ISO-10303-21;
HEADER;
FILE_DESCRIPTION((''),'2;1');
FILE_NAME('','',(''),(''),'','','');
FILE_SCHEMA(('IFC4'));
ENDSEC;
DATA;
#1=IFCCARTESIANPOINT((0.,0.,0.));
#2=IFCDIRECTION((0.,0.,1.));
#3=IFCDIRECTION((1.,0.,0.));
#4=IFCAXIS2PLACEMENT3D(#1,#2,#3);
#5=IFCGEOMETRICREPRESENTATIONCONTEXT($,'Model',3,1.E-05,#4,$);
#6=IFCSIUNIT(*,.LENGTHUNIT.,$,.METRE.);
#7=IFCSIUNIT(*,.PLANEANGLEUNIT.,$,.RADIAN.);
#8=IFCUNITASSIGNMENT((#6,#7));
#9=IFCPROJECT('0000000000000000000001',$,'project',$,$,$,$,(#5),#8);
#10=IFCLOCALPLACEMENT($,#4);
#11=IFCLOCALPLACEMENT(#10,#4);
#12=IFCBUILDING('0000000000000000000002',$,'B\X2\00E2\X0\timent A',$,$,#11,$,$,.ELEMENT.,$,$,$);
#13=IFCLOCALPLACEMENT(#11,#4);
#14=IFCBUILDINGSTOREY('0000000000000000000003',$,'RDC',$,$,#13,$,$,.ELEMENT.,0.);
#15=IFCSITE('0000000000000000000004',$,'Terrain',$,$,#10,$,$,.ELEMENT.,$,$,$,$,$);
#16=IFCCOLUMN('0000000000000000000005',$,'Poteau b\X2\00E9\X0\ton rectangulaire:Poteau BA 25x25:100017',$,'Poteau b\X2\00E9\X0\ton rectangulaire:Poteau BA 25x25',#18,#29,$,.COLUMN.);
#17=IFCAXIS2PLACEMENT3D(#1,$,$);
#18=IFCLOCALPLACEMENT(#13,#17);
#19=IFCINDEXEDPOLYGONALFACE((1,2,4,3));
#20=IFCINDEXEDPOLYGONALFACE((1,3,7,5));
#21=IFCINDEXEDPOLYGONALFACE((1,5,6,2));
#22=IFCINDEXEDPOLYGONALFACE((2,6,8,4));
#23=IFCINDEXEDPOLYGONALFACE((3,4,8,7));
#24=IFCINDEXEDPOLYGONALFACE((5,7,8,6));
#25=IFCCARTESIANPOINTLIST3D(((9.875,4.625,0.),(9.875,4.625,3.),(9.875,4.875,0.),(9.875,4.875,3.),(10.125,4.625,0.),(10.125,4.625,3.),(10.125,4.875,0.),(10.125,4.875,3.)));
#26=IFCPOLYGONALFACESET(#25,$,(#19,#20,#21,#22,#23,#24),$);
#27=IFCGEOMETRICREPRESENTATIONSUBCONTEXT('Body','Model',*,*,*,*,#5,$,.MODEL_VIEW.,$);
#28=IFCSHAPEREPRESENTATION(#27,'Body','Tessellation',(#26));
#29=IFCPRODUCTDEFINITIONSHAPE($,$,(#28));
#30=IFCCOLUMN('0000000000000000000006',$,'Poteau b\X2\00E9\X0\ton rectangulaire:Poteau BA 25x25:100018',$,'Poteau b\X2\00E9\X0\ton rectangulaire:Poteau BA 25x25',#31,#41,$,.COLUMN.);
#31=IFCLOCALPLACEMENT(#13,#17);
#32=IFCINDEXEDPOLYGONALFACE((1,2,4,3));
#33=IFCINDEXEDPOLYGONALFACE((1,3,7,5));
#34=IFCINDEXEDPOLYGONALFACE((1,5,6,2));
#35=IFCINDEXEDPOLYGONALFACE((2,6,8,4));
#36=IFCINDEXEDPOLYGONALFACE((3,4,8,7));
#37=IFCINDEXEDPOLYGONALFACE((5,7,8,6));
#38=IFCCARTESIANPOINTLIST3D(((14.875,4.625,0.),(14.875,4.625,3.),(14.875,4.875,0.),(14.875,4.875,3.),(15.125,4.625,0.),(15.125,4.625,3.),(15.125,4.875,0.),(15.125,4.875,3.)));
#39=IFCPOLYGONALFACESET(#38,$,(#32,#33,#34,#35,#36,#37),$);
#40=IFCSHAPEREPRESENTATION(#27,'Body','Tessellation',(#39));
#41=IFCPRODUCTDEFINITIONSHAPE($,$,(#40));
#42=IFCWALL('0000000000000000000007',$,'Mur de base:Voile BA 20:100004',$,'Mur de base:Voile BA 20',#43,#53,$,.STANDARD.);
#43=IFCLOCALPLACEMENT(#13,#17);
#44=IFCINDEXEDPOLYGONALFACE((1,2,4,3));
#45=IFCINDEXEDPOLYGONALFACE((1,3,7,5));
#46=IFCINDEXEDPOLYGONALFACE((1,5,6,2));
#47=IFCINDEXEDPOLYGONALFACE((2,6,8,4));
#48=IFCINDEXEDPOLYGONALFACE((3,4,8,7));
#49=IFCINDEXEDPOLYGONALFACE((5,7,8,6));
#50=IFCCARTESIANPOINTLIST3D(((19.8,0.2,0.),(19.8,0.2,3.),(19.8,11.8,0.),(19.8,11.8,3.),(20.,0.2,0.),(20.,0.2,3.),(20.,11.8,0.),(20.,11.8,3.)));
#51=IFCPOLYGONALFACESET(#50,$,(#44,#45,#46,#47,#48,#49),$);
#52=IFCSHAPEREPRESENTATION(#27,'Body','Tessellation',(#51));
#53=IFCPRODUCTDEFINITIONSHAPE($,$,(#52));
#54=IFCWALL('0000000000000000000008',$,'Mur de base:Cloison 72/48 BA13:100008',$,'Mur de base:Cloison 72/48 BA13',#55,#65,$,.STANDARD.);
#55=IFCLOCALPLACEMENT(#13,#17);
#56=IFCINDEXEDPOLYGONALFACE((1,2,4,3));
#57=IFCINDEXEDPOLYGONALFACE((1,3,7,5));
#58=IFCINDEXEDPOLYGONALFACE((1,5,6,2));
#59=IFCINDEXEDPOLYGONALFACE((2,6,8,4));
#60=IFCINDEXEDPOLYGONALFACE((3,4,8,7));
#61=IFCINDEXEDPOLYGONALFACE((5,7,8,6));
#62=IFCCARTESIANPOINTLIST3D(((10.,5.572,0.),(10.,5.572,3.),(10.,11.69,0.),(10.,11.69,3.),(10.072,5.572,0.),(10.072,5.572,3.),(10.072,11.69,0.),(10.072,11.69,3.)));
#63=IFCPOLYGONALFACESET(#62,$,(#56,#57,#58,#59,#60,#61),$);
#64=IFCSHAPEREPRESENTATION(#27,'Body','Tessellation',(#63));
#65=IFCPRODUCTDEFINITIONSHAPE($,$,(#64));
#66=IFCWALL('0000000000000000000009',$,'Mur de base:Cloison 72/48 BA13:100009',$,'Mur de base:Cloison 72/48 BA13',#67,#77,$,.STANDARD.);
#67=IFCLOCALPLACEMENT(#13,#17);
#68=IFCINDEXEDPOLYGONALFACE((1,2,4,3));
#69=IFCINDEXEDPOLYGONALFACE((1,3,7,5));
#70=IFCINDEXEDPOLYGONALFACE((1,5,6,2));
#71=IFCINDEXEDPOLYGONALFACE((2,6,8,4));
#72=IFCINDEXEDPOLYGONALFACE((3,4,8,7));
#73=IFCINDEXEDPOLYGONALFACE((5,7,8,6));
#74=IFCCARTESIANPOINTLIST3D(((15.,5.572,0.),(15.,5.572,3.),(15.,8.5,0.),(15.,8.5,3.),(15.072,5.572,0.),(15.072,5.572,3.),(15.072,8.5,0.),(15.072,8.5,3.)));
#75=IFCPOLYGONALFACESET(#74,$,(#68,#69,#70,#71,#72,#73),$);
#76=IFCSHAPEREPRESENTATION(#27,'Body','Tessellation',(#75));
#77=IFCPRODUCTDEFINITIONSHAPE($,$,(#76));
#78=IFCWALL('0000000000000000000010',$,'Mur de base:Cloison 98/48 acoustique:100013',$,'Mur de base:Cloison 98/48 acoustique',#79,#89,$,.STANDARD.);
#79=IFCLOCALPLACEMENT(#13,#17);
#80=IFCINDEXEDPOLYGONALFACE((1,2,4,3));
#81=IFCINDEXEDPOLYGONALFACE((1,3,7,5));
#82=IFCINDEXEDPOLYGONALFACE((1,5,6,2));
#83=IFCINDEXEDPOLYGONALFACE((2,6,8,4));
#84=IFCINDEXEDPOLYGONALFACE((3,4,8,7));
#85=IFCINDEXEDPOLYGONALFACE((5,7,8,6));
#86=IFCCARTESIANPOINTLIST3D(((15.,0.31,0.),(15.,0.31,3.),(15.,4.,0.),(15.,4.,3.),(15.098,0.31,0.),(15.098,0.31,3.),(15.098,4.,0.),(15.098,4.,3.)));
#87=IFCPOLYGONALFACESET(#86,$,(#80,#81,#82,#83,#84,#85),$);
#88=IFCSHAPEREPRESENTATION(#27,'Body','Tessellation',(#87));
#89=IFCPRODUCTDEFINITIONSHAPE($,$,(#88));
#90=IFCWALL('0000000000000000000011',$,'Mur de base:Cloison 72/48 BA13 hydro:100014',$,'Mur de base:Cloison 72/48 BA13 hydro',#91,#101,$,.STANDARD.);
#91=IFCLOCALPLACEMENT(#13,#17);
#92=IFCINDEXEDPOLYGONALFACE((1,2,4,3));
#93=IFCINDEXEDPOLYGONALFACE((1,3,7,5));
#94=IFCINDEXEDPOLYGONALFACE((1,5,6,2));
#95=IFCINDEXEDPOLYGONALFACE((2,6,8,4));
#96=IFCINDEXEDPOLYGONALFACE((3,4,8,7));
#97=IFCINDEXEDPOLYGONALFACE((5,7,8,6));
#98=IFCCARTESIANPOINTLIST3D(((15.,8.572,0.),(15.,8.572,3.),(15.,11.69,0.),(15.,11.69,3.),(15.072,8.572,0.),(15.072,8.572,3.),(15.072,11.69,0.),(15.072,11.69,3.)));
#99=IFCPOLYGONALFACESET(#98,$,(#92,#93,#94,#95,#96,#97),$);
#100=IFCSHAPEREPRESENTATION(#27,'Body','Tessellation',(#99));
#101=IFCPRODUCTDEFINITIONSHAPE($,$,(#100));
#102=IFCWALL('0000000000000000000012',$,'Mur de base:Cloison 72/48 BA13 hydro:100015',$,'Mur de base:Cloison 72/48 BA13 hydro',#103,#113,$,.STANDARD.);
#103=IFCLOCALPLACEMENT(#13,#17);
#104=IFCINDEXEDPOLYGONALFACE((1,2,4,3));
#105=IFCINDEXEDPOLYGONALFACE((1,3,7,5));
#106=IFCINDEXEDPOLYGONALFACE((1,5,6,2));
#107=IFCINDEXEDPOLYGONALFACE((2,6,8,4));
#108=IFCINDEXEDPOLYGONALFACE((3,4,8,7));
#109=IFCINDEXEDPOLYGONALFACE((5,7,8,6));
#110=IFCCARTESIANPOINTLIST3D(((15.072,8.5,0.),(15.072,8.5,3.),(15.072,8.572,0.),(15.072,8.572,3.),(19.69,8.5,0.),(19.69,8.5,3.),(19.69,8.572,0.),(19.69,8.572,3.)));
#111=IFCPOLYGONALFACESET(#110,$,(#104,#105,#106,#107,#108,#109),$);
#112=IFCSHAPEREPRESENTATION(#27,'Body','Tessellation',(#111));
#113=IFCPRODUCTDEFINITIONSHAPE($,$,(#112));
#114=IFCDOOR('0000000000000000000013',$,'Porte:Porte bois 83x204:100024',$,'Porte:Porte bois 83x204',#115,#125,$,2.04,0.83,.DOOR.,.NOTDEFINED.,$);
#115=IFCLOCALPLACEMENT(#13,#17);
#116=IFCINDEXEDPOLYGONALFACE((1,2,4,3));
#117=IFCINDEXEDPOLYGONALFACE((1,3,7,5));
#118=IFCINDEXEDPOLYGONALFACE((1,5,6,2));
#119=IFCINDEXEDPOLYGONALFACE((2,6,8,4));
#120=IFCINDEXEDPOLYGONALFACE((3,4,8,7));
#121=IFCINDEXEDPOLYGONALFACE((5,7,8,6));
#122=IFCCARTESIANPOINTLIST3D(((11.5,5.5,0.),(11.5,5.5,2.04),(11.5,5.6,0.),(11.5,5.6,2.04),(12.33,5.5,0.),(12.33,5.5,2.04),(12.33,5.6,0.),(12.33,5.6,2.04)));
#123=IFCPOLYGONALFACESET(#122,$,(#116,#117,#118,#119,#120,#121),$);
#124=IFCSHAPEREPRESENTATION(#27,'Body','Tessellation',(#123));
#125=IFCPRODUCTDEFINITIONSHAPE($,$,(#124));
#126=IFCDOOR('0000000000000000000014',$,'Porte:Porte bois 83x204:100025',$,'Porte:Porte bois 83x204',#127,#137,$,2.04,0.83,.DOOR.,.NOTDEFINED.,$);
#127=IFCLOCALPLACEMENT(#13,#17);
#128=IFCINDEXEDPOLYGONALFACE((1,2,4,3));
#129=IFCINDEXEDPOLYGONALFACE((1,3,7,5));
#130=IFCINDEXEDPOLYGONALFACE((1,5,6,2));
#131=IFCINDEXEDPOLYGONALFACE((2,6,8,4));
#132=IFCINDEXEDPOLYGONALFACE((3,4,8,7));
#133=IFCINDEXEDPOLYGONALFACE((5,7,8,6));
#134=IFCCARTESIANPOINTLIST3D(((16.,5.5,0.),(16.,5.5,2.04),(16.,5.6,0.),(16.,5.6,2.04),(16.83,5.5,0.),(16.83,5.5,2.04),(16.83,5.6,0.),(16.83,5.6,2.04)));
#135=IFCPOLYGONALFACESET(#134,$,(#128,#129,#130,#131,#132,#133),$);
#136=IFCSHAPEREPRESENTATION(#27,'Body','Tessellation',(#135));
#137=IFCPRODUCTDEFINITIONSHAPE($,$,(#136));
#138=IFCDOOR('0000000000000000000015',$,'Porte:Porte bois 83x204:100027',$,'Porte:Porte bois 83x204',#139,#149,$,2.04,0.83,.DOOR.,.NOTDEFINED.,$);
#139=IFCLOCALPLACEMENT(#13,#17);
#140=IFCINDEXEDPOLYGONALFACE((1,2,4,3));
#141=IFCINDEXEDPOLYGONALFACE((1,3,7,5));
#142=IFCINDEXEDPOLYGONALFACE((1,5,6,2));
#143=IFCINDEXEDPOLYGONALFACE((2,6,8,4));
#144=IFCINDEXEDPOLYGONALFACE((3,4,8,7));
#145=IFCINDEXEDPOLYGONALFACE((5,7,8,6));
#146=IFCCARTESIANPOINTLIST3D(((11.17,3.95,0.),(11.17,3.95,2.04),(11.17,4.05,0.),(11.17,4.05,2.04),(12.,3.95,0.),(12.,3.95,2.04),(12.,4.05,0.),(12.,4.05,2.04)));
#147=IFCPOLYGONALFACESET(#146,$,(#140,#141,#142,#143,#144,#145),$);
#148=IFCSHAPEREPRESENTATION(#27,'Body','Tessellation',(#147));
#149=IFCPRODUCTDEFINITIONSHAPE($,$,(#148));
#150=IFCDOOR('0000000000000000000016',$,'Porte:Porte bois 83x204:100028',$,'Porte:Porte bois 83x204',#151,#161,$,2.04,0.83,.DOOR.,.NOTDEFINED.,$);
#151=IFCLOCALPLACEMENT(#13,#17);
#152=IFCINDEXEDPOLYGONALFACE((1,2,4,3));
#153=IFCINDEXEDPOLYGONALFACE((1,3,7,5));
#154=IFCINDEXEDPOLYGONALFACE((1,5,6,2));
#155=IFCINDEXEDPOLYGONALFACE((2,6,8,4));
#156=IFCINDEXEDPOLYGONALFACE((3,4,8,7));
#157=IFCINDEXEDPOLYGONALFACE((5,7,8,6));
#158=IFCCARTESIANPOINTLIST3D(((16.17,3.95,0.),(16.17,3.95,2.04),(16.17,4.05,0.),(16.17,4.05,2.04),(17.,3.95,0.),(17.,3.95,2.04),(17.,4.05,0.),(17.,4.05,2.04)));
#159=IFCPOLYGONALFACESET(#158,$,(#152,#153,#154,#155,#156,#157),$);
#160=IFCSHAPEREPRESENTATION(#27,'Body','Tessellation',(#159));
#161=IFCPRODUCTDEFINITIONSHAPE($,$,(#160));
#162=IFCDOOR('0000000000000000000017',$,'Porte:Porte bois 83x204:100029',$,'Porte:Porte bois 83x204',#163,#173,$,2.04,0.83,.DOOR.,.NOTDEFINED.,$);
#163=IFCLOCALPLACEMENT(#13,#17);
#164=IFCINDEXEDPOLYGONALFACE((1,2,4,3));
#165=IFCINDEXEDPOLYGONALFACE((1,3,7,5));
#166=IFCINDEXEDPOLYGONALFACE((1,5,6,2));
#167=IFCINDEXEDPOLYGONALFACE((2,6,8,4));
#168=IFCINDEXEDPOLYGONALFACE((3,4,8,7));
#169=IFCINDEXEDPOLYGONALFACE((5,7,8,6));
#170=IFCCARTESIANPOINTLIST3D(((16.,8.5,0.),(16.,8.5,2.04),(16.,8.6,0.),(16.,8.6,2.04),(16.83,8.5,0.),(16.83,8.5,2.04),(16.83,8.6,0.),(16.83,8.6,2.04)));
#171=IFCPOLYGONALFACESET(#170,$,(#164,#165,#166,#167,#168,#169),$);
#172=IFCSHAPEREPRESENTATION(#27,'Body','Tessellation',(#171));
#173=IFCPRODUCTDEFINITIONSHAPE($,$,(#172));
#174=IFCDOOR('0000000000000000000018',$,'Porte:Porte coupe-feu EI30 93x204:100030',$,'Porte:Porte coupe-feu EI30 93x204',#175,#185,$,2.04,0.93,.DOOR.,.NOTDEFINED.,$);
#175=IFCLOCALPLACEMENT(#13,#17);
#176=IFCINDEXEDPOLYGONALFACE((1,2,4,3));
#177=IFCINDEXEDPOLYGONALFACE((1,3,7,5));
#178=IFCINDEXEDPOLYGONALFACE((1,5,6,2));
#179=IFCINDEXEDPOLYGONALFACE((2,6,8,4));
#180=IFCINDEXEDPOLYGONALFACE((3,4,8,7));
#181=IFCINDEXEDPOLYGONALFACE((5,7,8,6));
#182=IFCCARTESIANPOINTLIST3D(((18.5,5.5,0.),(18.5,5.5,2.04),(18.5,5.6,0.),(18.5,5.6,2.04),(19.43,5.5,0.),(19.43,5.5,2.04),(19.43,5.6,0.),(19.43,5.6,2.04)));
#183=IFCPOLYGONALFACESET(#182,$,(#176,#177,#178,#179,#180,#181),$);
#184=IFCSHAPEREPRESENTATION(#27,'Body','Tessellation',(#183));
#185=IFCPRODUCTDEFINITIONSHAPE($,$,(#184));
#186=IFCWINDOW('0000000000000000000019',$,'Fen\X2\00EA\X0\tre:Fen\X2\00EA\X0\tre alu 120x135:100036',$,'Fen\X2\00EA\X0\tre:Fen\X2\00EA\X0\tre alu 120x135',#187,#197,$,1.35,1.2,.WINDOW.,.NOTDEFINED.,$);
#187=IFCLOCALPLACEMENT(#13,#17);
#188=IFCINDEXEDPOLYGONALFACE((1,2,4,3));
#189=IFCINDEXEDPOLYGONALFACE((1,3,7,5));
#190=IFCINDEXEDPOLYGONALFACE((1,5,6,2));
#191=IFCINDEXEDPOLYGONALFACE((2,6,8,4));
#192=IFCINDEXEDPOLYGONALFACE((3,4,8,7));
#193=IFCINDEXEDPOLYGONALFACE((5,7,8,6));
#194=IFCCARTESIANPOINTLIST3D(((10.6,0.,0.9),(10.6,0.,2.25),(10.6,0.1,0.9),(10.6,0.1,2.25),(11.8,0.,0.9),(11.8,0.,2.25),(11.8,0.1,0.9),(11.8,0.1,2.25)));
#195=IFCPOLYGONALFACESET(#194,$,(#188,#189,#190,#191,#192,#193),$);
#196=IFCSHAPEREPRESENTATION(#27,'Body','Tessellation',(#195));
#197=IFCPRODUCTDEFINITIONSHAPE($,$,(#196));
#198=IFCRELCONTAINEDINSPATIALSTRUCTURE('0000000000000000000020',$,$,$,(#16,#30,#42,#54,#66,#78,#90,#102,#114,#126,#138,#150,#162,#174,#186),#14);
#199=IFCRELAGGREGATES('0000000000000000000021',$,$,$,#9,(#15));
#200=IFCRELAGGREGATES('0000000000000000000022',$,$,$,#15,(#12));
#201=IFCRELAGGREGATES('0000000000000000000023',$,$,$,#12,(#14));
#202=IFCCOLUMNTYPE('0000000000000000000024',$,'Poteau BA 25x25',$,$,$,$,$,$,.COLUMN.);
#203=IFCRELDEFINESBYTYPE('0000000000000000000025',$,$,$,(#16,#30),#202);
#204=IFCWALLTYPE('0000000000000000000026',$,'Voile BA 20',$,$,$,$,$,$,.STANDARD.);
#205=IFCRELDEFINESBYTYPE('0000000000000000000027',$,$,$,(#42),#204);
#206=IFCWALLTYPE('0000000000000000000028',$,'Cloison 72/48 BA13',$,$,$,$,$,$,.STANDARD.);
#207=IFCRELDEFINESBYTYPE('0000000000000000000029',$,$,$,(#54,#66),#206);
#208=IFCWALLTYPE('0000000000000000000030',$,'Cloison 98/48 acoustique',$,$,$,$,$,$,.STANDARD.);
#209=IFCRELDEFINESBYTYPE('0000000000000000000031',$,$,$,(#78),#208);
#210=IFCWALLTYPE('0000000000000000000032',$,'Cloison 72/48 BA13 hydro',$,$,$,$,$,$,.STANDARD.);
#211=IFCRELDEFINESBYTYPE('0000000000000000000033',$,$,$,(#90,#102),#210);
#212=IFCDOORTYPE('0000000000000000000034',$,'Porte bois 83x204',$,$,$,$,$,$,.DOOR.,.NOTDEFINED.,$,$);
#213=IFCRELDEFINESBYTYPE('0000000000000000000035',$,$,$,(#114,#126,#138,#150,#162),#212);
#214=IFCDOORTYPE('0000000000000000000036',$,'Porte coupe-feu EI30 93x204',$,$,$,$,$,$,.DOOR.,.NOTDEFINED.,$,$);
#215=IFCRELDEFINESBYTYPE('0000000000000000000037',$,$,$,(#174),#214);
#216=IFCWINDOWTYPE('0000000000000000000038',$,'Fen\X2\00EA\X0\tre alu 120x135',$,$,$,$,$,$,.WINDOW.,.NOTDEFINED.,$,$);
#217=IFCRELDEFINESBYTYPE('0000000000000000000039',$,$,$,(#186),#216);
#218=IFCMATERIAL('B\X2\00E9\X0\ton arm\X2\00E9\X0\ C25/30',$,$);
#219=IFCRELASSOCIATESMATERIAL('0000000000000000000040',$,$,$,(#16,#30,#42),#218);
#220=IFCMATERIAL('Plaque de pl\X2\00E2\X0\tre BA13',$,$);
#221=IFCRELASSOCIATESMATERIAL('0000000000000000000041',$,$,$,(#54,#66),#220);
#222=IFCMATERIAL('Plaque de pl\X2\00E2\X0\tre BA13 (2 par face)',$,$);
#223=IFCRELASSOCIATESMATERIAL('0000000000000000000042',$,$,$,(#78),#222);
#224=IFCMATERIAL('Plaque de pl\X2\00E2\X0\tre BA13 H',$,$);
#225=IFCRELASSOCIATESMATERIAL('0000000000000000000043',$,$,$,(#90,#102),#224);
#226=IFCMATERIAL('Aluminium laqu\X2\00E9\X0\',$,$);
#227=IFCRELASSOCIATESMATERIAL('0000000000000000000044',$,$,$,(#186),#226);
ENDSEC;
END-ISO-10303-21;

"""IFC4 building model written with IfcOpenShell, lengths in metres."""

from ifc_helpers import new_model, si_unit, frame, frame_2d, origin_with_axes, place, context, subcontext, project, spatial, rectangle, extrude, material, type_object, element, save


model = new_model("IFC4")

# Units and contexts
model_context = context("Model", 3, precision=1e-05, world=origin_with_axes())
body_context = subcontext(model_context, "Body", "Model", "MODEL_VIEW")
ifc_project = project(units=[si_unit("LENGTHUNIT", "METRE"), si_unit("PLANEANGLEUNIT", "RADIAN")], contexts=[model_context])

# Site, building, storey
site_placement = place(None, origin_with_axes())
site = spatial("IfcSite", under=ifc_project, at=site_placement, Name="Terrain", CompositionType="ELEMENT")
building_placement = place(site_placement, origin_with_axes())
building = spatial("IfcBuilding", under=site, at=building_placement, Name="Bâtiment A", CompositionType="ELEMENT")
storey_placement = place(building_placement, origin_with_axes())
storey = spatial("IfcBuildingStorey", under=building, at=storey_placement, Name="RDC", CompositionType="ELEMENT", Elevation=0.0)

# Columns
ifc_material_1 = material(Name="Béton armé C25/30")
column_type = type_object("IfcColumnType", Name="Poteau BA 25x25", PredefinedType="COLUMN")
for number, where, z_axis, x_axis, name in (
    (1, (9.875, 4.625, 0.0), (0.0, 0.0, 1.0), (1.0, 0.0, 0.0), "Poteau béton rectangulaire:Poteau BA 25x25:100017"),
    (2, (14.875, 4.625, 0.0), (0.0, 0.0, 1.0), (1.0, 0.0, 0.0), "Poteau béton rectangulaire:Poteau BA 25x25:100018"),
):
    element("IfcColumn", number, at=place(storey_placement, frame(where, z_axis=z_axis, x_axis=x_axis)), inside=storey, type_object=column_type, material=ifc_material_1, Name=name, ObjectType="Poteau béton rectangulaire:Poteau BA 25x25", PredefinedType="COLUMN", context=body_context, shape_type="SweptSolid", body=[
        extrude(rectangle(XDim=0.25, YDim=0.25, at=frame_2d((0.125, 0.125))), origin_with_axes(), (0.0, 0.0, 1.0), 3.0),
    ])

# Walls
wall_type_1 = type_object("IfcWallType", Name="Voile BA 20", PredefinedType="STANDARD")
wall_1_placement = place(storey_placement, frame((20.0, 0.2, 0.0), z_axis=(0.0, 0.0, 1.0), x_axis=(0.0, 1.0, 0.0)))
element("IfcWall", 3, at=wall_1_placement, inside=storey, type_object=wall_type_1, material=ifc_material_1, Name="Mur de base:Voile BA 20:100004", ObjectType="Mur de base:Voile BA 20", PredefinedType="STANDARD", context=body_context, shape_type="SweptSolid", body=[
    extrude(rectangle(XDim=11.6, YDim=0.2, at=frame_2d((5.8, 0.1))), origin_with_axes(), (0.0, 0.0, 1.0), 3.0),
])
ifc_material_2 = material(Name="Plaque de plâtre BA13")
wall_type_2 = type_object("IfcWallType", Name="Cloison 72/48 BA13", PredefinedType="STANDARD")
wall_2_placement = place(storey_placement, frame((10.072, 5.572, 0.0), z_axis=(0.0, 0.0, 1.0), x_axis=(0.0, 1.0, 0.0)))
element("IfcWall", 4, at=wall_2_placement, inside=storey, type_object=wall_type_2, material=ifc_material_2, Name="Mur de base:Cloison 72/48 BA13:100008", ObjectType="Mur de base:Cloison 72/48 BA13", PredefinedType="STANDARD", context=body_context, shape_type="SweptSolid", body=[
    extrude(rectangle(XDim=6.118, YDim=0.072, at=frame_2d((3.059, 0.036))), origin_with_axes(), (0.0, 0.0, 1.0), 3.0),
])
wall_3_placement = place(storey_placement, frame((15.072, 5.572, 0.0), z_axis=(0.0, 0.0, 1.0), x_axis=(0.0, 1.0, 0.0)))
element("IfcWall", 5, at=wall_3_placement, inside=storey, type_object=wall_type_2, material=ifc_material_2, Name="Mur de base:Cloison 72/48 BA13:100009", ObjectType="Mur de base:Cloison 72/48 BA13", PredefinedType="STANDARD", context=body_context, shape_type="SweptSolid", body=[
    extrude(rectangle(XDim=2.928, YDim=0.072, at=frame_2d((1.464, 0.036))), origin_with_axes(), (0.0, 0.0, 1.0), 3.0),
])
ifc_material_3 = material(Name="Plaque de plâtre BA13 (2 par face)")
wall_type_3 = type_object("IfcWallType", Name="Cloison 98/48 acoustique", PredefinedType="STANDARD")
wall_4_placement = place(storey_placement, frame((15.098, 0.31, 0.0), z_axis=(0.0, 0.0, 1.0), x_axis=(0.0, 1.0, 0.0)))
element("IfcWall", 6, at=wall_4_placement, inside=storey, type_object=wall_type_3, material=ifc_material_3, Name="Mur de base:Cloison 98/48 acoustique:100013", ObjectType="Mur de base:Cloison 98/48 acoustique", PredefinedType="STANDARD", context=body_context, shape_type="SweptSolid", body=[
    extrude(rectangle(XDim=3.69, YDim=0.098, at=frame_2d((1.845, 0.049))), origin_with_axes(), (0.0, 0.0, 1.0), 3.0),
])
ifc_material_4 = material(Name="Plaque de plâtre BA13 H")
wall_type_4 = type_object("IfcWallType", Name="Cloison 72/48 BA13 hydro", PredefinedType="STANDARD")
wall_5_placement = place(storey_placement, frame((15.072, 8.572, 0.0), z_axis=(0.0, 0.0, 1.0), x_axis=(0.0, 1.0, 0.0)))
element("IfcWall", 7, at=wall_5_placement, inside=storey, type_object=wall_type_4, material=ifc_material_4, Name="Mur de base:Cloison 72/48 BA13 hydro:100014", ObjectType="Mur de base:Cloison 72/48 BA13 hydro", PredefinedType="STANDARD", context=body_context, shape_type="SweptSolid", body=[
    extrude(rectangle(XDim=3.118, YDim=0.072, at=frame_2d((1.559, 0.036))), origin_with_axes(), (0.0, 0.0, 1.0), 3.0),
])
wall_6_placement = place(storey_placement, frame((15.072, 8.5, 0.0), z_axis=(0.0, 0.0, 1.0), x_axis=(1.0, 0.0, 0.0)))
element("IfcWall", 8, at=wall_6_placement, inside=storey, type_object=wall_type_4, material=ifc_material_4, Name="Mur de base:Cloison 72/48 BA13 hydro:100015", ObjectType="Mur de base:Cloison 72/48 BA13 hydro", PredefinedType="STANDARD", context=body_context, shape_type="SweptSolid", body=[
    extrude(rectangle(XDim=4.618, YDim=0.072, at=frame_2d((2.309, 0.036))), origin_with_axes(), (0.0, 0.0, 1.0), 3.0),
])

# Doors
door_type_1 = type_object("IfcDoorType", Name="Porte bois 83x204", OperationType="NOTDEFINED", PredefinedType="DOOR")
for number, where, z_axis, x_axis, name in (
    (9, (11.5, 5.5, 0.0), (0.0, 0.0, 1.0), (1.0, 0.0, 0.0), "Porte:Porte bois 83x204:100024"),
    (10, (16.0, 5.5, 0.0), (0.0, 0.0, 1.0), (1.0, 0.0, 0.0), "Porte:Porte bois 83x204:100025"),
    (11, (11.17, 3.95, 0.0), (0.0, 0.0, 1.0), (1.0, 0.0, 0.0), "Porte:Porte bois 83x204:100027"),
    (12, (16.17, 3.95, 0.0), (0.0, 0.0, 1.0), (1.0, 0.0, 0.0), "Porte:Porte bois 83x204:100028"),
    (13, (16.0, 8.5, 0.0), (0.0, 0.0, 1.0), (1.0, 0.0, 0.0), "Porte:Porte bois 83x204:100029"),
):
    element("IfcDoor", number, at=place(storey_placement, frame(where, z_axis=z_axis, x_axis=x_axis)), inside=storey, type_object=door_type_1, Name=name, ObjectType="Porte:Porte bois 83x204", OperationType="NOTDEFINED", OverallHeight=2.04, OverallWidth=0.83, PredefinedType="DOOR", context=body_context, shape_type="SweptSolid", body=[
        extrude(rectangle(XDim=0.83, YDim=0.1, at=frame_2d((0.415, 0.05))), origin_with_axes(), (0.0, 0.0, 1.0), 2.04),
    ])
door_type_2 = type_object("IfcDoorType", Name="Porte coupe-feu EI30 93x204", OperationType="NOTDEFINED", PredefinedType="DOOR")
door_placement = place(storey_placement, frame((18.5, 5.5, 0.0), z_axis=(0.0, 0.0, 1.0), x_axis=(1.0, 0.0, 0.0)))
element("IfcDoor", 14, at=door_placement, inside=storey, type_object=door_type_2, Name="Porte:Porte coupe-feu EI30 93x204:100030", ObjectType="Porte:Porte coupe-feu EI30 93x204", OperationType="NOTDEFINED", OverallHeight=2.04, OverallWidth=0.93, PredefinedType="DOOR", context=body_context, shape_type="SweptSolid", body=[
    extrude(rectangle(XDim=0.93, YDim=0.1, at=frame_2d((0.465, 0.05))), origin_with_axes(), (0.0, 0.0, 1.0), 2.04),
])

# Window
ifc_material_5 = material(Name="Aluminium laqué")
window_type_1 = type_object("IfcWindowType", Name="Fenêtre alu 120x135", PartitioningType="NOTDEFINED", PredefinedType="WINDOW")
for number, where, z_axis, x_axis, name in (
    (15, (10.6, 0.0, 0.9), (0.0, 0.0, 1.0), (1.0, 0.0, 0.0), "Fenêtre:Fenêtre alu 120x135:100036"),
):
    element("IfcWindow", number, at=place(storey_placement, frame(where, z_axis=z_axis, x_axis=x_axis)), inside=storey, type_object=window_type_1, material=ifc_material_5, Name=name, ObjectType="Fenêtre:Fenêtre alu 120x135", OverallHeight=1.35, OverallWidth=1.2, PartitioningType="NOTDEFINED", PredefinedType="WINDOW", context=body_context, shape_type="SweptSolid", body=[
        extrude(rectangle(XDim=1.2, YDim=0.1, at=frame_2d((0.6, 0.05))), origin_with_axes(), (0.0, 0.0, 1.0), 1.35),
    ])

save(model, "model.ifc")
